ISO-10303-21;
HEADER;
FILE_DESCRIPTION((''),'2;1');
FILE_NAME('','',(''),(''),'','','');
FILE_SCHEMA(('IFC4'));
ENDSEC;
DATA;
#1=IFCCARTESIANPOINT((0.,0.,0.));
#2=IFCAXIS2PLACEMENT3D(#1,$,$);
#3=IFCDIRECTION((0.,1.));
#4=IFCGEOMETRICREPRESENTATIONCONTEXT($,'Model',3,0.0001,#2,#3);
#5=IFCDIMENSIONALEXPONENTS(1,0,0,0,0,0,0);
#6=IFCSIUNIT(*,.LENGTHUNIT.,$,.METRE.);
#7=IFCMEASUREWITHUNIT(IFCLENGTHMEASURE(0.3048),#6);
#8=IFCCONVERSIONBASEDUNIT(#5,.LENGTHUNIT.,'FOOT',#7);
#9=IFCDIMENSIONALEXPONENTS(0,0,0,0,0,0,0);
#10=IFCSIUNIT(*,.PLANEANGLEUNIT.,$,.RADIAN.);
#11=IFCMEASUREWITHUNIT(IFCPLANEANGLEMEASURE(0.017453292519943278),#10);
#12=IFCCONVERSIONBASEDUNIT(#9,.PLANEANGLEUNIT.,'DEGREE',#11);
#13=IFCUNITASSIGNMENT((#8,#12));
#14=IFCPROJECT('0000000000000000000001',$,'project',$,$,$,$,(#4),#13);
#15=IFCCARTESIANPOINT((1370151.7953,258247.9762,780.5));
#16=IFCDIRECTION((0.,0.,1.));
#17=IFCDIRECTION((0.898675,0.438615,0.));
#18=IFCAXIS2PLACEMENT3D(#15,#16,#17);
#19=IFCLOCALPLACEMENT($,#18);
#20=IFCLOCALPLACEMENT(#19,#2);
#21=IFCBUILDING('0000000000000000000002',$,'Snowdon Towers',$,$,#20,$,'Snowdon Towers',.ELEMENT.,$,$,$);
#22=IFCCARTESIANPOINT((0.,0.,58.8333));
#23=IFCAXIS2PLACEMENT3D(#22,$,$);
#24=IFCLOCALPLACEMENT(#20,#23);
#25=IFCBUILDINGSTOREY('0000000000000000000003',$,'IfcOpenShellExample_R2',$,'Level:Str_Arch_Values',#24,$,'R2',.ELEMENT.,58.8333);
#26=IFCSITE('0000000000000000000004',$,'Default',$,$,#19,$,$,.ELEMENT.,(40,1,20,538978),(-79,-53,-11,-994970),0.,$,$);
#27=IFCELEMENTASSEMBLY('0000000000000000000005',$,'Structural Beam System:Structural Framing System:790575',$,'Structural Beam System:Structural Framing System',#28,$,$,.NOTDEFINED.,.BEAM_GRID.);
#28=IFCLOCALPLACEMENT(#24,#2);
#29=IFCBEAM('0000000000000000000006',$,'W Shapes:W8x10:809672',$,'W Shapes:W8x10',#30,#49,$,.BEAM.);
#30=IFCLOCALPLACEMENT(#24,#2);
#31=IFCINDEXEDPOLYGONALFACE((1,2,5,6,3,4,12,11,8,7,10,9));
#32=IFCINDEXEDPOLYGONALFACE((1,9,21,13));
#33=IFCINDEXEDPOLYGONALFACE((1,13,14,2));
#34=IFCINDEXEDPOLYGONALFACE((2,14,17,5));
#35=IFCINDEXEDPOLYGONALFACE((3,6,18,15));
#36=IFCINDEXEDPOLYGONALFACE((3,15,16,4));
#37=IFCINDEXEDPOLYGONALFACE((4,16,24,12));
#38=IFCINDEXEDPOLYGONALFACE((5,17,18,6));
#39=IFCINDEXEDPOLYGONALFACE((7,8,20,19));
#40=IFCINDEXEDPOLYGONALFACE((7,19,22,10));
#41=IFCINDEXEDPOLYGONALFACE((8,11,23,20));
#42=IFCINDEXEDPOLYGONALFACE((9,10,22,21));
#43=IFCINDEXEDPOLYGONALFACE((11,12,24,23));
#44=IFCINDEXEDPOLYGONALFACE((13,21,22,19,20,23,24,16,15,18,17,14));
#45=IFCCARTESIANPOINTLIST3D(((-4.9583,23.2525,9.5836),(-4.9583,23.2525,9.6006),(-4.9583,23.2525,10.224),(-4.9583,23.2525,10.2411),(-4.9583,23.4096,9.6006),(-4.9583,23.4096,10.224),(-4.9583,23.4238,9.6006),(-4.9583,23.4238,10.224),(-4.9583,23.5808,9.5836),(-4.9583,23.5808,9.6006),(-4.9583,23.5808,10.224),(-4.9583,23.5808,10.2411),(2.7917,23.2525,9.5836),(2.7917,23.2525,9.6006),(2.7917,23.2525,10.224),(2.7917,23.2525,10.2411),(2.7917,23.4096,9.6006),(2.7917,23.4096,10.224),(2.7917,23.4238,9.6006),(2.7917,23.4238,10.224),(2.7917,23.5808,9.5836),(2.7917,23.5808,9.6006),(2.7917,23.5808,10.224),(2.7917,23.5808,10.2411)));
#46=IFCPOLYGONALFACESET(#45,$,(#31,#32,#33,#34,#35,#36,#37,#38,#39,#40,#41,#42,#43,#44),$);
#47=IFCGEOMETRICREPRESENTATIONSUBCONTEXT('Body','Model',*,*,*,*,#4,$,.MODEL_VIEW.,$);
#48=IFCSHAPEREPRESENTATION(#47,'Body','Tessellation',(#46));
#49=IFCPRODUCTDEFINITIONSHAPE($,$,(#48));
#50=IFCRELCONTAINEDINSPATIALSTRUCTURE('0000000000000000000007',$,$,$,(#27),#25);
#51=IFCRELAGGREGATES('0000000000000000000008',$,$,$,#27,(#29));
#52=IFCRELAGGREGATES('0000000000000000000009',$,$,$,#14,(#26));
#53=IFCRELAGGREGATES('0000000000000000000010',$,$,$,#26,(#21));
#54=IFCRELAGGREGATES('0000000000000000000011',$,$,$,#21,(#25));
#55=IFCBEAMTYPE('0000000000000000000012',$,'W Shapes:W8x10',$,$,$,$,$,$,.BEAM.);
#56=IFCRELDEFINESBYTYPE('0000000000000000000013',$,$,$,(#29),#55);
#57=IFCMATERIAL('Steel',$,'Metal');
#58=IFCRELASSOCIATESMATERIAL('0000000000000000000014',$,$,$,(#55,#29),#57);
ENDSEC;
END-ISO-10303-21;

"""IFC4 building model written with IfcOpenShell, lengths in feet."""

from ifc_helpers import new_model, entity, si_unit, converted_unit, direction, frame, origin, place, context, subcontext, project, spatial, indexed_curve, outline, extrude, source, transform, mapped, material, type_object, type_shapes, element, aggregate, save


model = new_model("IFC4")

# Units and contexts
model_context = context("Model", 3, precision=0.0001, world=origin(), true_north=direction((0.0, 1.0)))
body_context = subcontext(model_context, "Body", "Model", "MODEL_VIEW")
ifc_project = project(units=[converted_unit("LENGTHUNIT", "FOOT", entity("IfcLengthMeasure", 0.3048), si_unit("LENGTHUNIT", "METRE"), dimensions=[1, 0, 0, 0, 0, 0, 0]), converted_unit("PLANEANGLEUNIT", "DEGREE", entity("IfcPlaneAngleMeasure", 0.017453292519943278), si_unit("PLANEANGLEUNIT", "RADIAN"), dimensions=[0, 0, 0, 0, 0, 0, 0])], contexts=[model_context])

# Site, building, storey
site_placement = place(None, frame((1370151.7953, 258247.9762, 780.5), z_axis=(0.0, 0.0, 1.0), x_axis=(0.898675, 0.438615, 0.0)))
site = spatial("IfcSite", under=ifc_project, at=site_placement, Name="Default", CompositionType="ELEMENT", RefLatitude=(40, 1, 20, 538978), RefLongitude=(-79, -53, -11, -994970), RefElevation=0.0)
building_placement = place(site_placement, origin())
building = spatial("IfcBuilding", under=site, at=building_placement, Name="Snowdon Towers", LongName="Snowdon Towers", CompositionType="ELEMENT")
storey_placement = place(building_placement, frame((0.0, 0.0, 58.8333)))
storey = spatial("IfcBuildingStorey", under=building, at=storey_placement, Name="IfcOpenShellExample_R2", ObjectType="Level:Str_Arch_Values", LongName="R2", CompositionType="ELEMENT", Elevation=58.8333)

# Shared definitions
ifc_material_1 = material(Name="Steel", Category="Metal")

# Element assembly, beam
beam_type_1 = type_object("IfcBeamType", Name="W Shapes:W8x10", PredefinedType="BEAM", material=ifc_material_1)
shared_shape_1 = source(origin(), body_context, "Body", "SweptSolid", [
    extrude(outline(indexed_curve([(-0.1642, -0.3117), (-0.1642, -0.3288), (0.1642, -0.3288), (0.1642, -0.3117), (0.0071, -0.3117), (0.0071, 0.3117), (0.1642, 0.3117), (0.1642, 0.3287), (-0.1642, 0.3287), (-0.1642, 0.3117), (-0.0071, 0.3117), (-0.0071, -0.3117), (-0.1642, -0.3117)], self_intersect=False)), frame((-3.875, 0.0, 0.0), z_axis=(-1.0, 0.0, 0.0), x_axis=(0.0, -1.0, 0.0)), (0.0, 0.0, -1.0), 7.75),
])
type_shapes(beam_type_1, [shared_shape_1])
assembly_1_placement = place(storey_placement, origin())
assembly_1 = element("IfcElementAssembly", 1, at=assembly_1_placement, inside=storey, Name="Structural Beam System:Structural Framing System:790575", ObjectType="Structural Beam System:Structural Framing System", AssemblyPlace="NOTDEFINED", PredefinedType="BEAM_GRID")
beam_1_placement = place(assembly_1_placement, frame((-1.0833, 23.4167, 9.9123), z_axis=(0.0, 0.0, 1.0), x_axis=(-1.0, 0.0, 0.0)))
beam_1 = element("IfcBeam", 2, at=beam_1_placement, type_object=beam_type_1, material=ifc_material_1, Name="W Shapes:W8x10:809672", ObjectType="W Shapes:W8x10", PredefinedType="BEAM", context=body_context, shape_type="MappedRepresentation", body=[
    mapped(shared_shape_1, transform((0.0, 0.0, 0.0), scale=1.0)),
])
aggregate(assembly_1, [beam_1])

save(model, "model.ifc")
